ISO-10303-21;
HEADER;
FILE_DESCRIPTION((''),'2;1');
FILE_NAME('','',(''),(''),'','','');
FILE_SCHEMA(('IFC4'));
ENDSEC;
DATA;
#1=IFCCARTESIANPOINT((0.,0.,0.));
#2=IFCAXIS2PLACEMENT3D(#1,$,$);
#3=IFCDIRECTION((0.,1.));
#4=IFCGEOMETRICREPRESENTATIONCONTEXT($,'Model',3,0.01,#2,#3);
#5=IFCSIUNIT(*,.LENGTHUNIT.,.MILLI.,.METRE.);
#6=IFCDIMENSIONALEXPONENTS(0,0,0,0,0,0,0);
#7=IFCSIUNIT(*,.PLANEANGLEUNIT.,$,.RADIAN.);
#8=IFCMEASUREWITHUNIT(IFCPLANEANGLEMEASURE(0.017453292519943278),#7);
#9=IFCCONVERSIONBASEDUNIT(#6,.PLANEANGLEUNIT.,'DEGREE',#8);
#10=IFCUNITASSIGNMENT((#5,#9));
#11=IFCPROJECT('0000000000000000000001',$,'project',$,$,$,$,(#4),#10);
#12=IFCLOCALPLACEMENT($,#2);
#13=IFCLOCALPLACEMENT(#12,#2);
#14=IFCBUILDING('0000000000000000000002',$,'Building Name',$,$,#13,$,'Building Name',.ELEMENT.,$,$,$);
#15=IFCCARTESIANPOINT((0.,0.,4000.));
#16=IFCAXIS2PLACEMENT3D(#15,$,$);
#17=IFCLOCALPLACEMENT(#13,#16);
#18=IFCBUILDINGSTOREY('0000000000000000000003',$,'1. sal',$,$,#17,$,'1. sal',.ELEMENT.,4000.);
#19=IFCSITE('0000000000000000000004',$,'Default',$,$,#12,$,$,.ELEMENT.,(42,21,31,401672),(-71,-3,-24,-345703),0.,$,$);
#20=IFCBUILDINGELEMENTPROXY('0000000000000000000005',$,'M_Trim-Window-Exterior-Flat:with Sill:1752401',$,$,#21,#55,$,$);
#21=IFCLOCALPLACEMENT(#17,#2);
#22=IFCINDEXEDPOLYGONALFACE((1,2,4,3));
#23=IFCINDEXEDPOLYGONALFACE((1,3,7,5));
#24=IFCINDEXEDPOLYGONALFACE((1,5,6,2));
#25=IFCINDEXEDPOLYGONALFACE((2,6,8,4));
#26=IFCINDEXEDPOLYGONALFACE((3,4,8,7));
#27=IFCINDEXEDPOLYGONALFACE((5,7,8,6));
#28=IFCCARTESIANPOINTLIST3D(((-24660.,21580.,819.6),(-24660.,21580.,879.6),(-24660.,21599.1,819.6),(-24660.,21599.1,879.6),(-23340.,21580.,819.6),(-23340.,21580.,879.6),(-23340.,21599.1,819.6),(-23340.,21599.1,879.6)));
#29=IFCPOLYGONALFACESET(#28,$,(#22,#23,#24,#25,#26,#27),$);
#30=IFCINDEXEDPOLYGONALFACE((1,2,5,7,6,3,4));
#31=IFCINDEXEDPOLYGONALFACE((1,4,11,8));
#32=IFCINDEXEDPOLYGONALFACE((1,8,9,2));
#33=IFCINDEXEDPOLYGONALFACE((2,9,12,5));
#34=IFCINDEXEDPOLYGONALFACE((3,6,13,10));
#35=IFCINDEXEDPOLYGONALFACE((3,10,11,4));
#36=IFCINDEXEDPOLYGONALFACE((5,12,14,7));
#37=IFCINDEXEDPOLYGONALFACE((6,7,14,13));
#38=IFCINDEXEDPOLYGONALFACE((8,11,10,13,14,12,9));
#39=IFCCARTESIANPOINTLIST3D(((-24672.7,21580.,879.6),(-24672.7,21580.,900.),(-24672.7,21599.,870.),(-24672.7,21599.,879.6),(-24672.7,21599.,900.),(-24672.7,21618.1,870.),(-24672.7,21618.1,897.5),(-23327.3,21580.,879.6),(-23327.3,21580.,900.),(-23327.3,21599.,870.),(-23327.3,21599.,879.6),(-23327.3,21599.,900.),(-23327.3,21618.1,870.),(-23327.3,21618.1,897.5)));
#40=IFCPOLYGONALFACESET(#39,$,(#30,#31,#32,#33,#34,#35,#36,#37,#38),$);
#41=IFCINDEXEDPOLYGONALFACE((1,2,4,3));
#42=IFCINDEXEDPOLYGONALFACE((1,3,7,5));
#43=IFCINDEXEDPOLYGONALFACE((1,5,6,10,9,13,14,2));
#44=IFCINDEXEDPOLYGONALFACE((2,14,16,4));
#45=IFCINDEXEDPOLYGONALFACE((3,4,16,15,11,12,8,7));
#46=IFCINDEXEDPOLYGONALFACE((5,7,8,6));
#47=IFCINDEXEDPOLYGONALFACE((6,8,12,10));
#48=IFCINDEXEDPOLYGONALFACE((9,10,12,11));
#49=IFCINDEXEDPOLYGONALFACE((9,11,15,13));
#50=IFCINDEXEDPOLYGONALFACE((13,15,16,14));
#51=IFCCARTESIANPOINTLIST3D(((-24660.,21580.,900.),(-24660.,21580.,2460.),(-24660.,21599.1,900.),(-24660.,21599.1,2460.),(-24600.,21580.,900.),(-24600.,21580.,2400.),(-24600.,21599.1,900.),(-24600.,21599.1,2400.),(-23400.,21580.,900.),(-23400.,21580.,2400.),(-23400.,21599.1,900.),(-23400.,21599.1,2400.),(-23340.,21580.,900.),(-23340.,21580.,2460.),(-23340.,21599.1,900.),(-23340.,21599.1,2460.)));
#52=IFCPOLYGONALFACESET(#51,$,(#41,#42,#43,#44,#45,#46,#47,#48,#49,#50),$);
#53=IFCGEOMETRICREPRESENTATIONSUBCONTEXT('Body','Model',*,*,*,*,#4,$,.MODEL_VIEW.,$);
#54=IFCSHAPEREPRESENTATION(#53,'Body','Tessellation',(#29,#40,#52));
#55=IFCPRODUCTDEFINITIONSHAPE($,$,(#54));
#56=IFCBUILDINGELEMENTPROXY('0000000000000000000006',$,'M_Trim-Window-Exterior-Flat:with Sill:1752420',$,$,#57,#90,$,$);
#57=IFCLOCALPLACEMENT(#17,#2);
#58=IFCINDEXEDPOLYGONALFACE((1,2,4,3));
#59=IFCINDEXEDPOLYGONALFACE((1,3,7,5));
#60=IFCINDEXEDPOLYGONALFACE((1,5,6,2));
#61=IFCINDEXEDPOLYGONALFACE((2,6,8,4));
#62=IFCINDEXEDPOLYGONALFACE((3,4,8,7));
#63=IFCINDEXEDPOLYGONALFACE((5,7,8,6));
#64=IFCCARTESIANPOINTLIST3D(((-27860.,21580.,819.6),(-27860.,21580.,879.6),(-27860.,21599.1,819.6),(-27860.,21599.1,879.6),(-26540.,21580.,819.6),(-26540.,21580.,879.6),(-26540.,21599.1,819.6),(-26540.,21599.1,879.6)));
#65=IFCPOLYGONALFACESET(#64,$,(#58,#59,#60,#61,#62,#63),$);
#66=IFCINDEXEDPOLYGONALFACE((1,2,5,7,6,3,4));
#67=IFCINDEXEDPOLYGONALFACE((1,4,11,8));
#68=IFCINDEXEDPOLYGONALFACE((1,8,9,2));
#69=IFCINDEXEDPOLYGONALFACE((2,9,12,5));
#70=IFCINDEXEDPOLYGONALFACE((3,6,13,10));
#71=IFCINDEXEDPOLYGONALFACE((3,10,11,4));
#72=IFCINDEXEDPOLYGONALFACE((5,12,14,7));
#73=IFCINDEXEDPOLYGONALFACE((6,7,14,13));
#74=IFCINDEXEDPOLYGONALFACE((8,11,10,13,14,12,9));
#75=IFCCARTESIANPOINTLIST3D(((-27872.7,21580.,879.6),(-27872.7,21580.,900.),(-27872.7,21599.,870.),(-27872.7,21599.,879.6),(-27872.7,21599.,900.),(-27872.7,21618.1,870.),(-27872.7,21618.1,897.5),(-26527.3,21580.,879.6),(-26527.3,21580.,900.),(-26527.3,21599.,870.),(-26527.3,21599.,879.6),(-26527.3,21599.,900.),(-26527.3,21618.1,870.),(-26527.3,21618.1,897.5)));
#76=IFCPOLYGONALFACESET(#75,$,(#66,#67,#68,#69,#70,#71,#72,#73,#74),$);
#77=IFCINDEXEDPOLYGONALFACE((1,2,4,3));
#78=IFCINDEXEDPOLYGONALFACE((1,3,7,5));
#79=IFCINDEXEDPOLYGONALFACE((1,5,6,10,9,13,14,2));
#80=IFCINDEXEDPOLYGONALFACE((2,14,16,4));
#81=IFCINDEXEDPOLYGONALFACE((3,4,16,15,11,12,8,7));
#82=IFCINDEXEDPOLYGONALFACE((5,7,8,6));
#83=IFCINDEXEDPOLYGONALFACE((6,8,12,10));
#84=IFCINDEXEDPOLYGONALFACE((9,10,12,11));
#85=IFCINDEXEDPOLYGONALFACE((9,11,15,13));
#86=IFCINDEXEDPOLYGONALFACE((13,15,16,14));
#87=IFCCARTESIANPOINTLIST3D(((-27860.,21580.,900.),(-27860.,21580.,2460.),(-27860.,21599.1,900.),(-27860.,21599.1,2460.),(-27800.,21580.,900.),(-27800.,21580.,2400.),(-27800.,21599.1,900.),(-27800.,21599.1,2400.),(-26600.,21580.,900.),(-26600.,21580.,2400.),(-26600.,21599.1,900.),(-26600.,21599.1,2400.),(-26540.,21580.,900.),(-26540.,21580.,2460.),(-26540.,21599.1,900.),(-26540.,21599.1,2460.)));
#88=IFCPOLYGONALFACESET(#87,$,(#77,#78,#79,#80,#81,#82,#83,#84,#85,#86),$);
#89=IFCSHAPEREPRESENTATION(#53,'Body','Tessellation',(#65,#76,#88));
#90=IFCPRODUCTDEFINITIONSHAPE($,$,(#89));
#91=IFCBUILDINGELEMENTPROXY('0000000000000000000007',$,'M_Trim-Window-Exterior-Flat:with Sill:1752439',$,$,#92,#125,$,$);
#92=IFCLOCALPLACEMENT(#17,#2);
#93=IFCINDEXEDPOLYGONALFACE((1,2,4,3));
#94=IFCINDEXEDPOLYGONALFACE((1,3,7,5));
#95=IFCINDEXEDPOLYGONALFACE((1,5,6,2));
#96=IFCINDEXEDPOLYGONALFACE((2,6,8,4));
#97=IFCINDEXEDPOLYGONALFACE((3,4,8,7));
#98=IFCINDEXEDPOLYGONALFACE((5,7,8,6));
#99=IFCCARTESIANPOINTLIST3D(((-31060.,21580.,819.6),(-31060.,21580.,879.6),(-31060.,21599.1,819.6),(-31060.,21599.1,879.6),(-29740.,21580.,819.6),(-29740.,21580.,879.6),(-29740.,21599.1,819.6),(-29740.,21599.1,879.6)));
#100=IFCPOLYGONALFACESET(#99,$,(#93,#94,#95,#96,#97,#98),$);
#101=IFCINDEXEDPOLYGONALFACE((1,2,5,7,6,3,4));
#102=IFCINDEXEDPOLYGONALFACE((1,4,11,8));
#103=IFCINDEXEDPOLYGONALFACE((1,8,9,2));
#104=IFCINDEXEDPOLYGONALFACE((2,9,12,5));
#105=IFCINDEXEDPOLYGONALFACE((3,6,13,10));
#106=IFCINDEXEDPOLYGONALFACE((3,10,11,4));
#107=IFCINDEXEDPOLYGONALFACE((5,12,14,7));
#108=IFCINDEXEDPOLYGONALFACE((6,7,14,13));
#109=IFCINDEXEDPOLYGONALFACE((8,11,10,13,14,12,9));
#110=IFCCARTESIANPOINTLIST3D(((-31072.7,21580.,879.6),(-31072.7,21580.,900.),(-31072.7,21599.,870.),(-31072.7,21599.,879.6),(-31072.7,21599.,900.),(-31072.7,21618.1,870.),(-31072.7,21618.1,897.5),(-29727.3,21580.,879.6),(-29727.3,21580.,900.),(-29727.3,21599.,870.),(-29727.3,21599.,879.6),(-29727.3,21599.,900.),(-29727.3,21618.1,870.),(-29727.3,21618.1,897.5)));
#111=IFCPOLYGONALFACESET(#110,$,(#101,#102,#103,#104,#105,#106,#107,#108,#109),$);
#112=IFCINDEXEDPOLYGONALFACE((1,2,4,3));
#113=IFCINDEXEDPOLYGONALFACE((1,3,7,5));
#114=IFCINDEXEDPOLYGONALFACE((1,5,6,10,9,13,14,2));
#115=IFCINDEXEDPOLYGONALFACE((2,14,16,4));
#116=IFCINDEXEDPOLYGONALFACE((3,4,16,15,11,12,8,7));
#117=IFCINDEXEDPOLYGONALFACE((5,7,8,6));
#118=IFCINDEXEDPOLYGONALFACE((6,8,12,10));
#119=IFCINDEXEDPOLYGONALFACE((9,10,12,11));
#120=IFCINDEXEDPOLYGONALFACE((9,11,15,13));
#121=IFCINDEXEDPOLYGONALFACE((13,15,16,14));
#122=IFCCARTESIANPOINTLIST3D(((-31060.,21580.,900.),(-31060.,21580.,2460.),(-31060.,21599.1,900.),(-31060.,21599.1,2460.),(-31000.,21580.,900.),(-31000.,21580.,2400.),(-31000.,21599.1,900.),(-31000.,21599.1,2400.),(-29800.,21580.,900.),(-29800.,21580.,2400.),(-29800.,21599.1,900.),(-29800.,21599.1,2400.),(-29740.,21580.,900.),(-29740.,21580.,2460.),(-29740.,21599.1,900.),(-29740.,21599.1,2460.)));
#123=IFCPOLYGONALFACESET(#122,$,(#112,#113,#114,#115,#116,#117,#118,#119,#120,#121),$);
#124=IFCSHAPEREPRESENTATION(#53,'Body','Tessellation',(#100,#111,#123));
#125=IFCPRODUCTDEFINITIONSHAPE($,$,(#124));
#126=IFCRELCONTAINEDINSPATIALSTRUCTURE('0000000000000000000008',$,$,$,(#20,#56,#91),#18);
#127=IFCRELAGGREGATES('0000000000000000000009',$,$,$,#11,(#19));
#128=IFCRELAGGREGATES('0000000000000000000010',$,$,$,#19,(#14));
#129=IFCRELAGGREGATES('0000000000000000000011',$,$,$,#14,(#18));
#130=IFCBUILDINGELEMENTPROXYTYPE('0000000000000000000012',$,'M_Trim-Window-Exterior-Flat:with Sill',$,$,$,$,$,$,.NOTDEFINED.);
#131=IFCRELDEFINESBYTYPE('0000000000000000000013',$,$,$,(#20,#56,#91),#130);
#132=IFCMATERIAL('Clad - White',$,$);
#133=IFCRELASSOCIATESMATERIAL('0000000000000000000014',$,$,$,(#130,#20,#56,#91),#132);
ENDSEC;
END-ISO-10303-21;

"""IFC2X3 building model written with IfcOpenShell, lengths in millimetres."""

from ifc_helpers import new_model, entity, si_unit, converted_unit, direction, frame, frame_2d, origin, place, context, subcontext, project, spatial, polyline, rectangle, outline, extrude, source, transform, mapped, material, type_object, type_shapes, element, save


model = new_model("IFC2X3")

# Units and contexts
model_context = context("Model", 3, precision=0.01, world=origin(), true_north=direction((0.0, 1.0)))
body_context = subcontext(model_context, "Body", "Model", "MODEL_VIEW")
ifc_project = project(units=[si_unit("LENGTHUNIT", "METRE", prefix="MILLI"), converted_unit("PLANEANGLEUNIT", "DEGREE", entity("IfcPlaneAngleMeasure", 0.017453292519943278), si_unit("PLANEANGLEUNIT", "RADIAN"), dimensions=[0, 0, 0, 0, 0, 0, 0])], contexts=[model_context])

# Site, building, storey
site_placement = place(None, origin())
site = spatial("IfcSite", under=ifc_project, at=site_placement, Name="Default", CompositionType="ELEMENT", RefLatitude=(42, 21, 31, 401672), RefLongitude=(-71, -3, -24, -345703), RefElevation=0.0)
building_placement = place(site_placement, origin())
building = spatial("IfcBuilding", under=site, at=building_placement, Name="Building Name", LongName="Building Name", CompositionType="ELEMENT")
storey_placement = place(building_placement, frame((0.0, 0.0, 4000.0)))
storey = spatial("IfcBuildingStorey", under=building, at=storey_placement, Name="1. sal", LongName="1. sal", CompositionType="ELEMENT", Elevation=4000.0)

# Building element proxies
ifc_material_1 = material(Name="Clad - White")
building_element_proxy_type_1 = type_object("IfcBuildingElementProxyType", Name="M_Trim-Window-Exterior-Flat:with Sill", PredefinedType="NOTDEFINED", material=ifc_material_1)
shared_shape_1 = source(origin(), body_context, "Body", "SweptSolid", [
    extrude(rectangle(XDim=1320.0, YDim=60.0, at=frame_2d((0.0, 0.0), x_axis=(1.0, 0.0))), frame((0.0, -1550.4, 0.0), z_axis=(0.0, 0.0, 1.0), x_axis=(-1.0, 0.0, 0.0)), (0.0, 0.0, 1.0), 19.0),
    extrude(outline(polyline([(-19.0, -15.2), (0.0, -15.2), (0.0, -5.7), (19.0, -5.7), (19.0, 14.8), (0.0, 14.8), (-19.0, 12.3), (-19.0, -15.2)])), frame((-672.7, -1514.8, 19.0), z_axis=(1.0, 0.0, 0.0), x_axis=(0.0, 0.0, -1.0)), (0.0, 0.0, 1.0), 1345.4),
    extrude(outline(polyline([(-795.0, -660.0), (765.0, -660.0), (765.0, -600.0), (-735.0, -600.0), (-735.0, 600.0), (765.0, 600.0), (765.0, 660.0), (-795.0, 660.0), (-795.0, -660.0)])), frame((0.0, -735.0, 0.0), z_axis=(0.0, 0.0, 1.0), x_axis=(0.0, -1.0, 0.0)), (0.0, 0.0, 1.0), 19.0),
])
type_shapes(building_element_proxy_type_1, [shared_shape_1])
for number, where, z_axis, x_axis, name in (
    (1, (-24000.0, 21580.0, 2400.0), (0.0, 1.0, 0.0), (-1.0, 0.0, 0.0), "M_Trim-Window-Exterior-Flat:with Sill:1752401"),
    (2, (-27200.0, 21580.0, 2400.0), (0.0, 1.0, 0.0), (-1.0, 0.0, 0.0), "M_Trim-Window-Exterior-Flat:with Sill:1752420"),
    (3, (-30400.0, 21580.0, 2400.0), (0.0, 1.0, 0.0), (-1.0, 0.0, 0.0), "M_Trim-Window-Exterior-Flat:with Sill:1752439"),
):
    element("IfcBuildingElementProxy", number, at=place(storey_placement, frame(where, z_axis=z_axis, x_axis=x_axis)), inside=storey, type_object=building_element_proxy_type_1, material=ifc_material_1, Name=name, context=body_context, shape_type="MappedRepresentation", body=[
        mapped(shared_shape_1, transform((0.0, 0.0, 0.0), scale=1.0)),
    ])

save(model, "model.ifc")
